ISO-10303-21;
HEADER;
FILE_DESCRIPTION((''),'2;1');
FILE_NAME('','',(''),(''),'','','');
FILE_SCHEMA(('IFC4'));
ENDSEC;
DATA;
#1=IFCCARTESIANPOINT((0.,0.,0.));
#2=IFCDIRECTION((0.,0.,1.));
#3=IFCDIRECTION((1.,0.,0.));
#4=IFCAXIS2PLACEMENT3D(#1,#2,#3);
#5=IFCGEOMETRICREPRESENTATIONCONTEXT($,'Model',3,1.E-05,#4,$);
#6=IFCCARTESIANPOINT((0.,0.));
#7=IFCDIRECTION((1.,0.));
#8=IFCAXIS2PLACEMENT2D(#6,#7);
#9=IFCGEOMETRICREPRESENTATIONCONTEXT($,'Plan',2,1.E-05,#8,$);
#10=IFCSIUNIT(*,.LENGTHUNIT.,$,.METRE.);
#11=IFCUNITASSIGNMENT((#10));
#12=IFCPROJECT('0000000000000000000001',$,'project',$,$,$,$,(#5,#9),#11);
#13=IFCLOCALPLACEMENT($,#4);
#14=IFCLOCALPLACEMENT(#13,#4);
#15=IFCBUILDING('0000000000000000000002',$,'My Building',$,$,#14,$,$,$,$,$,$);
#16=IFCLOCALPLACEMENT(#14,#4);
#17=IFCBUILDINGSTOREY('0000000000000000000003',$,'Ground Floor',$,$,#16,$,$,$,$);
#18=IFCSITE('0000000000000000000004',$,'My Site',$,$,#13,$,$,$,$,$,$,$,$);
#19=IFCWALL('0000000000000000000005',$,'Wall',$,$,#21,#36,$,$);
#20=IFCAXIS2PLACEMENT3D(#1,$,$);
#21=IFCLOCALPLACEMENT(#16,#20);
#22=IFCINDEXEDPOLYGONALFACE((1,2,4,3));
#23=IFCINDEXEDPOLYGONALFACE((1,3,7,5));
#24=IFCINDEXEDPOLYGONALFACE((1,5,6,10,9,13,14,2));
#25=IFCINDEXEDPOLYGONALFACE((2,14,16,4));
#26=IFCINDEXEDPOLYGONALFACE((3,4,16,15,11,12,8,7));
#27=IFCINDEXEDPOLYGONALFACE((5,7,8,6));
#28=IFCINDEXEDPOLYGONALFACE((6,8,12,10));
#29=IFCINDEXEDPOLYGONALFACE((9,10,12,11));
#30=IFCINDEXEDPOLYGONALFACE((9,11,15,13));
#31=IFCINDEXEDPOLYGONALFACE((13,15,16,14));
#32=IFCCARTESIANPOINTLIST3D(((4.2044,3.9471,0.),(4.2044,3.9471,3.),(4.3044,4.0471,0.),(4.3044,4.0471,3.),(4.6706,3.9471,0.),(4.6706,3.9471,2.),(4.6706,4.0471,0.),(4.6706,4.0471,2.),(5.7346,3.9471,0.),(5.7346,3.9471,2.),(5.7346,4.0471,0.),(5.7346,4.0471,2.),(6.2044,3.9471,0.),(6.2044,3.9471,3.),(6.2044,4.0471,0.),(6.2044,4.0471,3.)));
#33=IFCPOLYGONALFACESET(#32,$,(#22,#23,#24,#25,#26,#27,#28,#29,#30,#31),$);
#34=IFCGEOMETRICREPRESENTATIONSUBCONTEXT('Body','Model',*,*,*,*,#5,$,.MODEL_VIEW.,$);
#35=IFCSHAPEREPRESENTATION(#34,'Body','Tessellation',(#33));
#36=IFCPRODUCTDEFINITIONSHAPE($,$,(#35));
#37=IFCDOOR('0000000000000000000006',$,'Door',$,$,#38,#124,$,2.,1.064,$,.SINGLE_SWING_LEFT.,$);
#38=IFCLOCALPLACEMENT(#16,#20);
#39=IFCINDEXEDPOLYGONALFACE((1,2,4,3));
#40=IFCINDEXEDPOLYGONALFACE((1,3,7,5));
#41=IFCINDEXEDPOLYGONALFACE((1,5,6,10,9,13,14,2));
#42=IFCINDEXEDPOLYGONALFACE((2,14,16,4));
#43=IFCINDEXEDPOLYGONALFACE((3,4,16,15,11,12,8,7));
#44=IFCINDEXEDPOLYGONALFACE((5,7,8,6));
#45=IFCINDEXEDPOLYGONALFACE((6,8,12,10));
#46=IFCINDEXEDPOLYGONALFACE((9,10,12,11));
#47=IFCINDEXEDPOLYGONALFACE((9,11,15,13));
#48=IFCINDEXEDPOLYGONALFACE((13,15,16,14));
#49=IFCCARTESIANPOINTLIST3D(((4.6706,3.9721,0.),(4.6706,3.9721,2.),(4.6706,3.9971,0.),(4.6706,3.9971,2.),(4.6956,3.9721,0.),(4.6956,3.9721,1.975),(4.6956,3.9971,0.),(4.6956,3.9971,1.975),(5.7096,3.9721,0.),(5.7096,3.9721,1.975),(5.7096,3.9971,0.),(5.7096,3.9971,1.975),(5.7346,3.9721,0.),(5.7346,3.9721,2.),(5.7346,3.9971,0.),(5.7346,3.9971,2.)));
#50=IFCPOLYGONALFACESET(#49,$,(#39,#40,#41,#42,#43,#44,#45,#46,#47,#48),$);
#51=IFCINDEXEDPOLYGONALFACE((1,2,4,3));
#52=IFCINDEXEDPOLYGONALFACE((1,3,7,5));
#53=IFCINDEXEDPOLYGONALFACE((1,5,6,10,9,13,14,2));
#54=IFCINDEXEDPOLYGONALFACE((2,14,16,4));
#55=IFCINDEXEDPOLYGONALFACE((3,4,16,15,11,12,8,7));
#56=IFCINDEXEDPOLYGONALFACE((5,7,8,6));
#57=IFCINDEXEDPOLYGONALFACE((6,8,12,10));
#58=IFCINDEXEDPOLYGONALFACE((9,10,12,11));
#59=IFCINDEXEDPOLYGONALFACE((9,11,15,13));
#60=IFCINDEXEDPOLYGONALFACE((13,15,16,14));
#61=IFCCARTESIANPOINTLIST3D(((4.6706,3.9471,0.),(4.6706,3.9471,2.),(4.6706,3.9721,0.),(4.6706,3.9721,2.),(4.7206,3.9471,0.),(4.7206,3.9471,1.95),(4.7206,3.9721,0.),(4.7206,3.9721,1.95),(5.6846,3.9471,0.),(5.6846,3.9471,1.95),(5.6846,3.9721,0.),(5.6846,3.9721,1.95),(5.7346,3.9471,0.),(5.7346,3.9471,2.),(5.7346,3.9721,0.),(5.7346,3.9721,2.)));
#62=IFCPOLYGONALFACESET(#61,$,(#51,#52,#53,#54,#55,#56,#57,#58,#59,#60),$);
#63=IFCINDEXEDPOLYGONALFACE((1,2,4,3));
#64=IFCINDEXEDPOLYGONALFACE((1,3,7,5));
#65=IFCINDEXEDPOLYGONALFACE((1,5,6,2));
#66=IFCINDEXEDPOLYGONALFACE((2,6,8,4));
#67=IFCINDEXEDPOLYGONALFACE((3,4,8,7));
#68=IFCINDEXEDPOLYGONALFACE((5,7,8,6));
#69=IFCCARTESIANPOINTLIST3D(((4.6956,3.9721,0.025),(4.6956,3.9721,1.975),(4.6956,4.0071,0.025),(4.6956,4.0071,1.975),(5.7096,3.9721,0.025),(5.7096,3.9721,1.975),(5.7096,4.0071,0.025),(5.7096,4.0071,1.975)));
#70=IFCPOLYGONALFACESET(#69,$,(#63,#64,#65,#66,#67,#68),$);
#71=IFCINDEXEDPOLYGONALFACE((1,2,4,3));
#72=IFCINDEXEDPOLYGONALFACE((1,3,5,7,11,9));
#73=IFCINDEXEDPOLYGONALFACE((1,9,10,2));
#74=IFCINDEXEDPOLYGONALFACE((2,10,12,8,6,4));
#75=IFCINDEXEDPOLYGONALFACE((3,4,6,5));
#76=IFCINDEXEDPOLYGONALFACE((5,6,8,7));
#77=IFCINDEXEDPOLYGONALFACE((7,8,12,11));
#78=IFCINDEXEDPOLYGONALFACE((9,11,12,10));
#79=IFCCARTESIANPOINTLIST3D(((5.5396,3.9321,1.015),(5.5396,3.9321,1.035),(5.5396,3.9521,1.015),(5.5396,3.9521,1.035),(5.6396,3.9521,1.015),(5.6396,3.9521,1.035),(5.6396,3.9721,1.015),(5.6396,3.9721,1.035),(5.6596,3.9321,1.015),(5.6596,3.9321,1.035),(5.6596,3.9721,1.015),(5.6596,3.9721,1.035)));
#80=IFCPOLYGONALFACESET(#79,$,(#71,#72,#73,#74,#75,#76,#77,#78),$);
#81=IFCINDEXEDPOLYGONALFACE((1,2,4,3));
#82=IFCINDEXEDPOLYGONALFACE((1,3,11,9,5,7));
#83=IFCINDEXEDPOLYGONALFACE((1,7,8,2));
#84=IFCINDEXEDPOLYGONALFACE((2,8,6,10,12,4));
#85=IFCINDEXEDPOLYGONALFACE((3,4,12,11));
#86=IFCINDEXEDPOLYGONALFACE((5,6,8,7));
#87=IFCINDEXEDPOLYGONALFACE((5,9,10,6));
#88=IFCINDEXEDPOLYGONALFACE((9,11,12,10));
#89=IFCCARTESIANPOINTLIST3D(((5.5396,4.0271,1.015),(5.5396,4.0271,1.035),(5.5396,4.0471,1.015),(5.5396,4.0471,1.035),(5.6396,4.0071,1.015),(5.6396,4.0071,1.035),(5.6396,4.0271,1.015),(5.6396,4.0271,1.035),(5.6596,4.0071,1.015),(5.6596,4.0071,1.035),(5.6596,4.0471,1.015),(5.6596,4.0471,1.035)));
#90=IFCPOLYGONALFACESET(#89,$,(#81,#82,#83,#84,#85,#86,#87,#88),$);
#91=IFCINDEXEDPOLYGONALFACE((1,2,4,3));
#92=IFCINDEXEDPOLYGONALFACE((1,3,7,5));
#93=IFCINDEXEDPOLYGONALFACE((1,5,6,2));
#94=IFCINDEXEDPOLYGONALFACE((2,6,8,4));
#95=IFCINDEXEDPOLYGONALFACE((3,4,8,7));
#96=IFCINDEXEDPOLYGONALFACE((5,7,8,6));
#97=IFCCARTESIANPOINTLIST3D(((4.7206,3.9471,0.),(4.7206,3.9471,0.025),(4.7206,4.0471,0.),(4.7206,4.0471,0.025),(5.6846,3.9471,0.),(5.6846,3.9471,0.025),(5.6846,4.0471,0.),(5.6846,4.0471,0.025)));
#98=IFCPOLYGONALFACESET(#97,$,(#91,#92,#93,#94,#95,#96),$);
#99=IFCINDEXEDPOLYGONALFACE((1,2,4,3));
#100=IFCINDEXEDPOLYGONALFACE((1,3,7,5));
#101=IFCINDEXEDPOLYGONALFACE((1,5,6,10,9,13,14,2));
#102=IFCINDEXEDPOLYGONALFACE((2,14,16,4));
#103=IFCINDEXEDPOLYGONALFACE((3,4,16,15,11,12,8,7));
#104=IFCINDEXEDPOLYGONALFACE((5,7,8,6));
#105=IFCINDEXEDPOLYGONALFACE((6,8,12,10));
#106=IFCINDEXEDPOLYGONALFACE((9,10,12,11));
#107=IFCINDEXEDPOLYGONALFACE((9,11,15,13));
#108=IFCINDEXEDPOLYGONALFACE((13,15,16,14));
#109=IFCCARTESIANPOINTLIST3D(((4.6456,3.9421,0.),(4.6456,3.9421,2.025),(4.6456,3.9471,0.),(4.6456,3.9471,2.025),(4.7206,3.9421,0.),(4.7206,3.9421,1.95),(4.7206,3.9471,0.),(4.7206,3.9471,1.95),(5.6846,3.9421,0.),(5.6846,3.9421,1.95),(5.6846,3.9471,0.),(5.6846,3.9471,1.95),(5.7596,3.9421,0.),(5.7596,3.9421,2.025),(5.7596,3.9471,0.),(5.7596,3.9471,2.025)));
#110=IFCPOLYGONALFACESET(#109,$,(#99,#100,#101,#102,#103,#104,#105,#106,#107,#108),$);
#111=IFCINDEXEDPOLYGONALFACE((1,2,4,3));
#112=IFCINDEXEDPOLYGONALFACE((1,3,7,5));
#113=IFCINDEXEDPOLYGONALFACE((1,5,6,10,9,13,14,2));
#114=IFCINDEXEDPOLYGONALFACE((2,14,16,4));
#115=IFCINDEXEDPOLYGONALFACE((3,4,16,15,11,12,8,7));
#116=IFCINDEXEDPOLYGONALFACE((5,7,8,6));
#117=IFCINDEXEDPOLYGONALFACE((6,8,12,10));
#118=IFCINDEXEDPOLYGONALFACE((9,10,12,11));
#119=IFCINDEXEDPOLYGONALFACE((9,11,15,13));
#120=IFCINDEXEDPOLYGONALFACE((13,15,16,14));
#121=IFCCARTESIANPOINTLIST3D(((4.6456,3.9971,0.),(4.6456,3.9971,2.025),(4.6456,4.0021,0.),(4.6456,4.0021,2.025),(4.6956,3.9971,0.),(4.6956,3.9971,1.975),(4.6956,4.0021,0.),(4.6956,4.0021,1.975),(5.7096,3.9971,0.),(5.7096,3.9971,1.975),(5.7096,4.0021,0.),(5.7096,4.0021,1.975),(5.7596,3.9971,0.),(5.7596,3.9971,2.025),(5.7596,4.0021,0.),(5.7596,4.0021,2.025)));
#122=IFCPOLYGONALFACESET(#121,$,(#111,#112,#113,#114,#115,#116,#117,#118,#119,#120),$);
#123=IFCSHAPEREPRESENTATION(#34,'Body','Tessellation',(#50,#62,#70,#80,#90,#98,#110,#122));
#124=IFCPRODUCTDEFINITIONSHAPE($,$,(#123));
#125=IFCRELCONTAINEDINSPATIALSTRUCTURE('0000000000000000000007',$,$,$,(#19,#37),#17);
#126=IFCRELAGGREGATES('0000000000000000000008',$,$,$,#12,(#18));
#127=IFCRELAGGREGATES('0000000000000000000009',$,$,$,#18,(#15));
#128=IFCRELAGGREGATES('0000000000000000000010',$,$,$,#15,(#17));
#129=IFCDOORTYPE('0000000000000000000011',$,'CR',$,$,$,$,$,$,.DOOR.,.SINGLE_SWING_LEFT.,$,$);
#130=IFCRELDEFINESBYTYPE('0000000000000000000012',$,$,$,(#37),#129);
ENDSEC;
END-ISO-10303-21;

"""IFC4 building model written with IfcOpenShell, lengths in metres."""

from ifc_helpers import new_model, entity, si_unit, frame, origin_with_axes, origin_2d_with_axis, place, context, subcontext, project, spatial, line, indexed_curve, outline, extrude, shape, source, transform, mapped, type_object, type_shapes, element, fill, save


model = new_model("IFC4")

# Units and contexts
model_context = context("Model", 3, precision=1e-05, world=origin_with_axes())
plan_context = context("Plan", 2, precision=1e-05, world=origin_2d_with_axis())
body_context_1 = subcontext(model_context, "Body", "Model", "MODEL_VIEW")
body_context_2 = subcontext(plan_context, "Body", "Plan", "PLAN_VIEW")
ifc_project = project(units=[si_unit("LENGTHUNIT", "METRE")], contexts=[model_context, plan_context])

# Site, building, storey
site_placement = place(None, origin_with_axes())
site = spatial("IfcSite", under=ifc_project, at=site_placement, Name="My Site")
building_placement = place(site_placement, origin_with_axes())
building = spatial("IfcBuilding", under=site, at=building_placement, Name="My Building")
storey_placement = place(building_placement, origin_with_axes())
storey = spatial("IfcBuildingStorey", under=building, at=storey_placement, Name="Ground Floor")

# Wall, opening, door
wall_1_placement = place(storey_placement, frame((4.2044, 3.9471, 0.0), z_axis=(0.0, 0.0, 1.0), x_axis=(1.0, 0.0, 0.0)))
wall_1 = element("IfcWall", 1, at=wall_1_placement, inside=storey, Name="Wall", context=body_context_1, shape_type="SweptSolid", body=[
    extrude(outline(indexed_curve([(0.0, 0.0), (0.1, 0.1), (2.0, 0.1), (2.0, 0.0)], segments=[line(1, 2, 3, 4, 1)])), origin_with_axes(), (0.0, 0.0, 1.0), 3.0),
])
shared_shape_1 = source(origin_with_axes(), body_context_1, "Body", "SweptSolid", [
    extrude(outline(indexed_curve([(0.0, 0.0), (1.064, 0.0), (1.064, 2.0), (0.0, 2.0)], segments=[line(1, 2, 3, 4, 1)])), frame((0.0, -0.6, 0.0), z_axis=(0.0, -1.0, 0.0), x_axis=(1.0, 0.0, 0.0)), (0.0, 0.0, -1.0), 1.2),
])
opening_1_placement = place(wall_1_placement, frame((0.4661, 0.0, 0.0), z_axis=(0.0, 0.0, 1.0), x_axis=(1.0, 0.0, 0.0)))
opening_1 = element("IfcOpeningElement", 2, at=opening_1_placement, cuts=wall_1, PredefinedType="OPENING", context=body_context_1, shape_type="MappedRepresentation", body=[
    mapped(shared_shape_1, transform((0.0, 0.0, 0.0), x_axis=(1.0, 0.0, 0.0), y_axis=(0.0, 1.0, 0.0), z_axis=(0.0, 0.0, 1.0), scale=1.0)),
])
door_type_1 = type_object("IfcDoorType", Name="CR", OperationType="SINGLE_SWING_LEFT", PredefinedType="DOOR")
shared_shape_2 = source(origin_with_axes(), body_context_1, "Body", "SweptSolid", [
    extrude(outline(indexed_curve([(0.0, 0.0), (0.0, 2.0), (1.064, 2.0), (1.064, 0.0), (1.039, 0.0), (1.039, 1.975), (0.025, 1.975), (0.025, 0.0)], segments=[line(1, 2, 3, 4, 5, 6, 7, 8, 1)])), frame((0.0, 0.025, 0.0), z_axis=(0.0, -1.0, 0.0), x_axis=(1.0, 0.0, 0.0)), (0.0, 0.0, -1.0), 0.025),
    extrude(outline(indexed_curve([(0.0, 0.0), (0.0, 2.0), (1.064, 2.0), (1.064, 0.0), (1.014, 0.0), (1.014, 1.95), (0.05, 1.95), (0.05, 0.0)], segments=[line(1, 2, 3, 4, 5, 6, 7, 8, 1)])), frame((0.0, 0.0, 0.0), z_axis=(0.0, -1.0, 0.0), x_axis=(1.0, 0.0, 0.0)), (0.0, 0.0, -1.0), 0.025),
    extrude(outline(indexed_curve([(0.0, 0.0), (1.014, 0.0), (1.014, 0.035), (0.0, 0.035)], segments=[line(1, 2, 3, 4, 1)])), frame((0.025, 0.025, 0.025), z_axis=(0.0, 0.0, 1.0), x_axis=(1.0, 0.0, 0.0)), (0.0, 0.0, 1.0), 1.95),
    extrude(outline(indexed_curve([(0.0, 0.0), (0.0, -0.04), (-0.12, -0.04), (-0.12, -0.02), (-0.02, -0.02), (-0.02, 0.0)], segments=[line(1, 2, 3, 4, 5, 6, 1)])), frame((0.989, 0.025, 1.015), z_axis=(0.0, 0.0, 1.0), x_axis=(1.0, 0.0, 0.0)), (0.0, 0.0, 1.0), 0.02),
    extrude(outline(indexed_curve([(0.0, 0.0), (0.0, 0.04), (-0.12, 0.04), (-0.12, 0.02), (-0.02, 0.02), (-0.02, 0.0)], segments=[line(1, 2, 3, 4, 5, 6, 1)])), frame((0.989, 0.06, 1.015), z_axis=(0.0, 0.0, 1.0), x_axis=(1.0, 0.0, 0.0)), (0.0, 0.0, 1.0), 0.02),
    extrude(outline(indexed_curve([(0.0, 0.0), (0.964, 0.0), (0.964, 0.1), (0.0, 0.1)], segments=[line(1, 2, 3, 4, 1)])), frame((0.05, 0.0, 0.0), z_axis=(0.0, 0.0, 1.0), x_axis=(1.0, 0.0, 0.0)), (0.0, 0.0, 1.0), 0.025),
    extrude(outline(indexed_curve([(0.0, 0.0), (0.0, 2.025), (1.114, 2.025), (1.114, 0.0), (1.039, 0.0), (1.039, 1.95), (0.075, 1.95), (0.075, 0.0)], segments=[line(1, 2, 3, 4, 5, 6, 7, 8, 1)])), frame((-0.025, -0.005, 0.0), z_axis=(0.0, -1.0, 0.0), x_axis=(1.0, 0.0, 0.0)), (0.0, 0.0, -1.0), 0.005),
    extrude(outline(indexed_curve([(0.0, 0.0), (0.0, 2.025), (1.114, 2.025), (1.114, 0.0), (1.064, 0.0), (1.064, 1.975), (0.05, 1.975), (0.05, 0.0)], segments=[line(1, 2, 3, 4, 5, 6, 7, 8, 1)])), frame((-0.025, 0.05, 0.0), z_axis=(0.0, -1.0, 0.0), x_axis=(1.0, 0.0, 0.0)), (0.0, 0.0, -1.0), 0.005),
])
shared_shape_3 = source(origin_with_axes(), body_context_2, "Body", "Curve2D", [
    entity("IfcIndexedPolyCurve", entity("IfcCartesianPointList2D", [[0.0, 0.0], [0.0, 0.05], [0.025, 0.05], [0.025, 0.025], [0.05, 0.025], [0.05, 0.0]]), [entity("IfcLineIndex", [1, 2, 3, 4, 5, 6, 1])]),
    entity("IfcIndexedPolyCurve", entity("IfcCartesianPointList2D", [[1.064, 0.0], [1.064, 0.05], [1.039, 0.05], [1.039, 0.025], [1.014, 0.025], [1.014, 0.0]]), [entity("IfcLineIndex", [1, 2, 3, 4, 5, 6, 1])]),
    entity("IfcTrimmedCurve", entity("IfcEllipse", entity("IfcAxis2Placement2D", entity("IfcCartesianPoint", [0.06, 0.05]), entity("IfcDirection", [1.0, 0.0])), 0.979, 1.014), [entity("IfcCartesianPoint", [1.039, 0.05])], [entity("IfcCartesianPoint", [0.06, 1.064])], True, "CARTESIAN"),
    entity("IfcIndexedPolyCurve", entity("IfcCartesianPointList2D", [[0.025, 0.05], [0.06, 0.05], [0.06, 1.064], [0.025, 1.064]]), [entity("IfcLineIndex", [1, 2, 3, 4, 1])]),
])
type_shapes(door_type_1, [shared_shape_2, shared_shape_3])
door_1_placement = place(opening_1_placement, origin_with_axes())
door_1 = element("IfcDoor", 3, at=door_1_placement, inside=storey, type_object=door_type_1, Name="Door", OperationType="SINGLE_SWING_LEFT", OverallHeight=2.0, OverallWidth=1.064, shapes=[
    shape(body_context_1, "Body", "MappedRepresentation", [mapped(shared_shape_2, transform((0.0, 0.0, 0.0), x_axis=(1.0, 0.0, 0.0), y_axis=(0.0, 1.0, 0.0), z_axis=(0.0, 0.0, 1.0), scale=1.0))]),
    shape(body_context_2, "Body", "MappedRepresentation", [mapped(shared_shape_3, transform((0.0, 0.0, 0.0), x_axis=(1.0, 0.0, 0.0), y_axis=(0.0, 1.0, 0.0), z_axis=(0.0, 0.0, 1.0), scale=1.0))]),
])
fill(opening_1, door_1)

save(model, "model.ifc")
